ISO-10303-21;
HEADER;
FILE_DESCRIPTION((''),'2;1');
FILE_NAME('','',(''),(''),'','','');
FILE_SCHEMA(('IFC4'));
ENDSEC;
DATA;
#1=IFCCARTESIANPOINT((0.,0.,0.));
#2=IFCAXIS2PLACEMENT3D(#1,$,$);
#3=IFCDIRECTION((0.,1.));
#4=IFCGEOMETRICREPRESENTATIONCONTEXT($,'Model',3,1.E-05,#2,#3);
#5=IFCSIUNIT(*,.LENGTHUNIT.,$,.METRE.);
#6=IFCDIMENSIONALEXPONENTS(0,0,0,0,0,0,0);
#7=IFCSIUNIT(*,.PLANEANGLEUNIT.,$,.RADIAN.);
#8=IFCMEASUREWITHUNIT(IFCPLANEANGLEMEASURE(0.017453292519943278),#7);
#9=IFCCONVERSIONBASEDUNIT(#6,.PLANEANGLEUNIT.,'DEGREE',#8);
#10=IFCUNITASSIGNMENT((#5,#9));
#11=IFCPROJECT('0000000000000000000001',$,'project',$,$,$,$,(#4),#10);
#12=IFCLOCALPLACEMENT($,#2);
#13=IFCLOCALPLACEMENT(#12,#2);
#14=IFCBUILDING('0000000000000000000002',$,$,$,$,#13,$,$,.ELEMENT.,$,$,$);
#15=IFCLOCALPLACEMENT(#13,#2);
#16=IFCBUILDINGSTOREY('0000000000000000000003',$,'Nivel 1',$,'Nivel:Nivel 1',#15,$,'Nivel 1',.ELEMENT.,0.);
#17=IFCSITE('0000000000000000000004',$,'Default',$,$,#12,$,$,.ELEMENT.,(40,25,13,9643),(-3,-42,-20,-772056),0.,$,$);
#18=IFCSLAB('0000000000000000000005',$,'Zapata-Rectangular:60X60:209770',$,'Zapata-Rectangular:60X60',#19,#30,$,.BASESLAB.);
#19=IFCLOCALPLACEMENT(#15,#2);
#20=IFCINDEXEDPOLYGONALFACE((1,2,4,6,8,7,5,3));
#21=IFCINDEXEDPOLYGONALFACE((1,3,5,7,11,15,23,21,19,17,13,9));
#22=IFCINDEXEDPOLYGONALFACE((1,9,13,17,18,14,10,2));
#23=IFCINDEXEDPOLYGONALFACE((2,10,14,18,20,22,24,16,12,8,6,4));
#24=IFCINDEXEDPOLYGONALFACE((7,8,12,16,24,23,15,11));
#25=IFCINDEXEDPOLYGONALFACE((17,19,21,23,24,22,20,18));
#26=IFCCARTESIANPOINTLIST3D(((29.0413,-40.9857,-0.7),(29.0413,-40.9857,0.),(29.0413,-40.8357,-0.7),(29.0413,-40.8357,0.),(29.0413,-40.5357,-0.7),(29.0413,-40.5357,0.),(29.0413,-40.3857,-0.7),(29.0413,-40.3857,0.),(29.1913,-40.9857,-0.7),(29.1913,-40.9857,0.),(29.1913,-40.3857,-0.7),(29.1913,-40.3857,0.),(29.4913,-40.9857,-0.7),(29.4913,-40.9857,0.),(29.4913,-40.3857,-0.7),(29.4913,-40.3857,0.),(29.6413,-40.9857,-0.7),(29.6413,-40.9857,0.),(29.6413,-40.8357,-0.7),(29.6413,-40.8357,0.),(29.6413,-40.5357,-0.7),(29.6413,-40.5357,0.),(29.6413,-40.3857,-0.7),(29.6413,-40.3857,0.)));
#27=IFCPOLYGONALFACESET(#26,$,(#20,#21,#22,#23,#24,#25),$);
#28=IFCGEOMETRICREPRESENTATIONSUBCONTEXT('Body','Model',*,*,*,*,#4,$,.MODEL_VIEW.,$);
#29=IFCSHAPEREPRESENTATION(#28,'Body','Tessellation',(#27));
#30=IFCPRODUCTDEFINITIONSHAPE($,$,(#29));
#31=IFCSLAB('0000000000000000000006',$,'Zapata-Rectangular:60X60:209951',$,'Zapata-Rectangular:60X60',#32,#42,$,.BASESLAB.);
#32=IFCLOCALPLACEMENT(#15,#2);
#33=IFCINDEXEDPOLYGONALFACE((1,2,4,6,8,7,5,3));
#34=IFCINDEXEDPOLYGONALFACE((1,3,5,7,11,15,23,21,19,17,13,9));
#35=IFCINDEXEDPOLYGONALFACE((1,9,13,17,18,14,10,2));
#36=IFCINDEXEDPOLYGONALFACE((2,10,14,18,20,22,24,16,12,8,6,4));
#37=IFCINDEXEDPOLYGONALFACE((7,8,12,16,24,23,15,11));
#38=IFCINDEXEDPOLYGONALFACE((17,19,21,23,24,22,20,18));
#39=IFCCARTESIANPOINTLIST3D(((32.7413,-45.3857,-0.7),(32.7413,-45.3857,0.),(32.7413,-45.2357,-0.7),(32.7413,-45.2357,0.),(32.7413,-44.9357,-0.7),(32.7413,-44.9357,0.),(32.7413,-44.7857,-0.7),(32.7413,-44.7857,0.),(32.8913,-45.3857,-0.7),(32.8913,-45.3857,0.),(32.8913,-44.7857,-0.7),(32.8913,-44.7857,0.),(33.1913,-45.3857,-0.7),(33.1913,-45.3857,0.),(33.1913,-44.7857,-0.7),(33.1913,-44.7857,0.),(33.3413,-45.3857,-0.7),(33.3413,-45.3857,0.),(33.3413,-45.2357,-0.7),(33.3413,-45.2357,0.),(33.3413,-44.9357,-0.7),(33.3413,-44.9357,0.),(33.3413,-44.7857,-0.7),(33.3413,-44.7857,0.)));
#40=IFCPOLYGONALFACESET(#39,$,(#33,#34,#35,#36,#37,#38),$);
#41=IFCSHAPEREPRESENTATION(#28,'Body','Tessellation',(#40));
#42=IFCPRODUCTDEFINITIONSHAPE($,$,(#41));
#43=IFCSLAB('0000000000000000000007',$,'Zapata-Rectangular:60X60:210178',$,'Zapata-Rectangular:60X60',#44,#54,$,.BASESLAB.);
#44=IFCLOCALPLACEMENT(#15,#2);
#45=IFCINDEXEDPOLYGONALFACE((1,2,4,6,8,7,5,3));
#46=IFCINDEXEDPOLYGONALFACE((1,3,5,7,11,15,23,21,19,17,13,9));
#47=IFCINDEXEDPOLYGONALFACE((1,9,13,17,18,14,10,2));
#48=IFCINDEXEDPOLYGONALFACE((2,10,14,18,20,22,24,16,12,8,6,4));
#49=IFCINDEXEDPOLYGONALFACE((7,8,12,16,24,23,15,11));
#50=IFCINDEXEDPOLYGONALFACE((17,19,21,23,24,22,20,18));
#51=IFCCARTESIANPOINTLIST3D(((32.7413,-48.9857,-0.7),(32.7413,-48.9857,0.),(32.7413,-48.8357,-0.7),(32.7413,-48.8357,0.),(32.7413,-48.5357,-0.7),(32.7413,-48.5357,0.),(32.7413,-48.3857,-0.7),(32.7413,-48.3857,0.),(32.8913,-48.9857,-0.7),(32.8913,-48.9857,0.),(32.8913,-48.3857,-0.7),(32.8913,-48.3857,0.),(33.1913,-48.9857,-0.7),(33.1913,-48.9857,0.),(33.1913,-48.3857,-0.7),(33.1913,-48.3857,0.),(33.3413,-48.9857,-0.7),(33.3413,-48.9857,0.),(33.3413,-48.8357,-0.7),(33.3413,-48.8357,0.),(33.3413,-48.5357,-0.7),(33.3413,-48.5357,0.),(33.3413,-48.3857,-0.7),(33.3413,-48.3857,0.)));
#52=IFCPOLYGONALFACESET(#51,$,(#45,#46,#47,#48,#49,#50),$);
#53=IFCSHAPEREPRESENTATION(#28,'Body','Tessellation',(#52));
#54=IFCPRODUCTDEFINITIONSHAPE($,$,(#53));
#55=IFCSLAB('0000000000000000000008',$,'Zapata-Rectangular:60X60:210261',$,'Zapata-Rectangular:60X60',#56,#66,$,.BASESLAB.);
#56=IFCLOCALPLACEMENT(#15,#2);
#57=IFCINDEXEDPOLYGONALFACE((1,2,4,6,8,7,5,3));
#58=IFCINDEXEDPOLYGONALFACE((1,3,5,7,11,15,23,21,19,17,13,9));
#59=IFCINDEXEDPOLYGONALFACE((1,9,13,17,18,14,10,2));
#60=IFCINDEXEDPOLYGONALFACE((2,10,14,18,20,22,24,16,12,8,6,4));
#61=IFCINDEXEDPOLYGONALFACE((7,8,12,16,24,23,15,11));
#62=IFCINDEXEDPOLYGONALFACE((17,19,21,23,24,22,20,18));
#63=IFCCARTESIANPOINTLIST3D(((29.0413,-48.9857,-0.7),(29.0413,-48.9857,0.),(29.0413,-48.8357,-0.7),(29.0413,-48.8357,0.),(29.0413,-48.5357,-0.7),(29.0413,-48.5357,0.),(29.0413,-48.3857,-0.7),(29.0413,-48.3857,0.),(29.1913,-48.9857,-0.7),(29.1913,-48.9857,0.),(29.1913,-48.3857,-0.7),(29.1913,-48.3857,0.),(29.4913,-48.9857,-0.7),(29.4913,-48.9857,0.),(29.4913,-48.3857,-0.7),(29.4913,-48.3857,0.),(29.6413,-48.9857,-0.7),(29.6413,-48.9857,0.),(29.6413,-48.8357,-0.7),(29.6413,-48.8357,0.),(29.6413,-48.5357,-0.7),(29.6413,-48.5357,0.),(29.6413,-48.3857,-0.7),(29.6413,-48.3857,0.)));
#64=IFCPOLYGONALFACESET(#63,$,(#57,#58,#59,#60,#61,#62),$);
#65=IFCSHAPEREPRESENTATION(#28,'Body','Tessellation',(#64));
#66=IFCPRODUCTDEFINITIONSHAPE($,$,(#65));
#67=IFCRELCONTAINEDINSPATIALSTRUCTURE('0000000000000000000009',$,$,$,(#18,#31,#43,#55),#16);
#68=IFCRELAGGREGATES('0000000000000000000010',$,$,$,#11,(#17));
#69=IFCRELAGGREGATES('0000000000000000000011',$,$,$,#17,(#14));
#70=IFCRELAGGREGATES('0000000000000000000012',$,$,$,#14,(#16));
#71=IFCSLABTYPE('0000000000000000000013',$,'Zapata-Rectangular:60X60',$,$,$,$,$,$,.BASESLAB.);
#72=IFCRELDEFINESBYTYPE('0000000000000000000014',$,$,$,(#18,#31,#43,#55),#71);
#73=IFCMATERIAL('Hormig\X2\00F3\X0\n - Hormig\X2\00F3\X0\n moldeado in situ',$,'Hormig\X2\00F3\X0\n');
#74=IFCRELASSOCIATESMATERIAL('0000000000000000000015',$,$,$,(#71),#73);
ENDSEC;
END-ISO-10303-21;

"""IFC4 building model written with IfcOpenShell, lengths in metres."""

from ifc_helpers import new_model, entity, si_unit, converted_unit, direction, frame, origin, place, context, subcontext, project, spatial, indexed_curve, outline, extrude, material, type_object, element, save


model = new_model("IFC4")

# Units and contexts
model_context = context("Model", 3, precision=1e-05, world=origin(), true_north=direction((0.0, 1.0)))
body_context = subcontext(model_context, "Body", "Model", "MODEL_VIEW")
ifc_project = project(units=[si_unit("LENGTHUNIT", "METRE"), converted_unit("PLANEANGLEUNIT", "DEGREE", entity("IfcPlaneAngleMeasure", 0.017453292519943278), si_unit("PLANEANGLEUNIT", "RADIAN"), dimensions=[0, 0, 0, 0, 0, 0, 0])], contexts=[model_context])

# Site, building, storey
site_placement = place(None, origin())
site = spatial("IfcSite", under=ifc_project, at=site_placement, Name="Default", CompositionType="ELEMENT", RefLatitude=(40, 25, 13, 9643), RefLongitude=(-3, -42, -20, -772056), RefElevation=0.0)
building_placement = place(site_placement, origin())
building = spatial("IfcBuilding", under=site, at=building_placement, CompositionType="ELEMENT")
storey_placement = place(building_placement, origin())
storey = spatial("IfcBuildingStorey", under=building, at=storey_placement, Name="Nivel 1", ObjectType="Nivel:Nivel 1", LongName="Nivel 1", CompositionType="ELEMENT", Elevation=0.0)

# Slabs
ifc_material_1 = material(Name="Hormigón - Hormigón moldeado in situ", Category="Hormigón")
slab_type = type_object("IfcSlabType", Name="Zapata-Rectangular:60X60", PredefinedType="BASESLAB", material=ifc_material_1)
slab_1_placement = place(storey_placement, origin())
element("IfcSlab", 1, at=slab_1_placement, inside=storey, type_object=slab_type, Name="Zapata-Rectangular:60X60:209770", ObjectType="Zapata-Rectangular:60X60", PredefinedType="BASESLAB", context=body_context, shape_type="SweptSolid", body=[
    extrude(outline(indexed_curve([(-0.3, -0.3), (-0.15, -0.3), (0.15, -0.3), (0.3, -0.3), (0.3, -0.15), (0.3, 0.15), (0.3, 0.3), (0.15, 0.3), (-0.15, 0.3), (-0.3, 0.3), (-0.3, 0.15), (-0.3, -0.15), (-0.3, -0.3)], self_intersect=False)), frame((29.3413, -40.6857, -0.7), z_axis=(0.0, 0.0, 1.0), x_axis=(-1.0, 0.0, 0.0)), (0.0, 0.0, 1.0), 0.7),
])
slab_2_placement = place(storey_placement, origin())
element("IfcSlab", 2, at=slab_2_placement, inside=storey, type_object=slab_type, Name="Zapata-Rectangular:60X60:209951", ObjectType="Zapata-Rectangular:60X60", PredefinedType="BASESLAB", context=body_context, shape_type="SweptSolid", body=[
    extrude(outline(indexed_curve([(-0.3, -0.3), (-0.15, -0.3), (0.15, -0.3), (0.3, -0.3), (0.3, -0.15), (0.3, 0.15), (0.3, 0.3), (0.15, 0.3), (-0.15, 0.3), (-0.3, 0.3), (-0.3, 0.15), (-0.3, -0.15), (-0.3, -0.3)], self_intersect=False)), frame((33.0413, -45.0857, -0.7), z_axis=(0.0, 0.0, 1.0), x_axis=(-1.0, 0.0, 0.0)), (0.0, 0.0, 1.0), 0.7),
])
slab_3_placement = place(storey_placement, origin())
element("IfcSlab", 3, at=slab_3_placement, inside=storey, type_object=slab_type, Name="Zapata-Rectangular:60X60:210178", ObjectType="Zapata-Rectangular:60X60", PredefinedType="BASESLAB", context=body_context, shape_type="SweptSolid", body=[
    extrude(outline(indexed_curve([(-0.3, -0.3), (-0.15, -0.3), (0.15, -0.3), (0.3, -0.3), (0.3, -0.15), (0.3, 0.15), (0.3, 0.3), (0.15, 0.3), (-0.15, 0.3), (-0.3, 0.3), (-0.3, 0.15), (-0.3, -0.15), (-0.3, -0.3)], self_intersect=False)), frame((33.0413, -48.6857, -0.7), z_axis=(0.0, 0.0, 1.0), x_axis=(-1.0, 0.0, 0.0)), (0.0, 0.0, 1.0), 0.7),
])
slab_4_placement = place(storey_placement, origin())
element("IfcSlab", 4, at=slab_4_placement, inside=storey, type_object=slab_type, Name="Zapata-Rectangular:60X60:210261", ObjectType="Zapata-Rectangular:60X60", PredefinedType="BASESLAB", context=body_context, shape_type="SweptSolid", body=[
    extrude(outline(indexed_curve([(-0.3, -0.3), (-0.15, -0.3), (0.15, -0.3), (0.3, -0.3), (0.3, -0.15), (0.3, 0.15), (0.3, 0.3), (0.15, 0.3), (-0.15, 0.3), (-0.3, 0.3), (-0.3, 0.15), (-0.3, -0.15), (-0.3, -0.3)], self_intersect=False)), frame((29.3413, -48.6857, -0.7), z_axis=(0.0, 0.0, 1.0), x_axis=(-1.0, 0.0, 0.0)), (0.0, 0.0, 1.0), 0.7),
])

save(model, "model.ifc")
